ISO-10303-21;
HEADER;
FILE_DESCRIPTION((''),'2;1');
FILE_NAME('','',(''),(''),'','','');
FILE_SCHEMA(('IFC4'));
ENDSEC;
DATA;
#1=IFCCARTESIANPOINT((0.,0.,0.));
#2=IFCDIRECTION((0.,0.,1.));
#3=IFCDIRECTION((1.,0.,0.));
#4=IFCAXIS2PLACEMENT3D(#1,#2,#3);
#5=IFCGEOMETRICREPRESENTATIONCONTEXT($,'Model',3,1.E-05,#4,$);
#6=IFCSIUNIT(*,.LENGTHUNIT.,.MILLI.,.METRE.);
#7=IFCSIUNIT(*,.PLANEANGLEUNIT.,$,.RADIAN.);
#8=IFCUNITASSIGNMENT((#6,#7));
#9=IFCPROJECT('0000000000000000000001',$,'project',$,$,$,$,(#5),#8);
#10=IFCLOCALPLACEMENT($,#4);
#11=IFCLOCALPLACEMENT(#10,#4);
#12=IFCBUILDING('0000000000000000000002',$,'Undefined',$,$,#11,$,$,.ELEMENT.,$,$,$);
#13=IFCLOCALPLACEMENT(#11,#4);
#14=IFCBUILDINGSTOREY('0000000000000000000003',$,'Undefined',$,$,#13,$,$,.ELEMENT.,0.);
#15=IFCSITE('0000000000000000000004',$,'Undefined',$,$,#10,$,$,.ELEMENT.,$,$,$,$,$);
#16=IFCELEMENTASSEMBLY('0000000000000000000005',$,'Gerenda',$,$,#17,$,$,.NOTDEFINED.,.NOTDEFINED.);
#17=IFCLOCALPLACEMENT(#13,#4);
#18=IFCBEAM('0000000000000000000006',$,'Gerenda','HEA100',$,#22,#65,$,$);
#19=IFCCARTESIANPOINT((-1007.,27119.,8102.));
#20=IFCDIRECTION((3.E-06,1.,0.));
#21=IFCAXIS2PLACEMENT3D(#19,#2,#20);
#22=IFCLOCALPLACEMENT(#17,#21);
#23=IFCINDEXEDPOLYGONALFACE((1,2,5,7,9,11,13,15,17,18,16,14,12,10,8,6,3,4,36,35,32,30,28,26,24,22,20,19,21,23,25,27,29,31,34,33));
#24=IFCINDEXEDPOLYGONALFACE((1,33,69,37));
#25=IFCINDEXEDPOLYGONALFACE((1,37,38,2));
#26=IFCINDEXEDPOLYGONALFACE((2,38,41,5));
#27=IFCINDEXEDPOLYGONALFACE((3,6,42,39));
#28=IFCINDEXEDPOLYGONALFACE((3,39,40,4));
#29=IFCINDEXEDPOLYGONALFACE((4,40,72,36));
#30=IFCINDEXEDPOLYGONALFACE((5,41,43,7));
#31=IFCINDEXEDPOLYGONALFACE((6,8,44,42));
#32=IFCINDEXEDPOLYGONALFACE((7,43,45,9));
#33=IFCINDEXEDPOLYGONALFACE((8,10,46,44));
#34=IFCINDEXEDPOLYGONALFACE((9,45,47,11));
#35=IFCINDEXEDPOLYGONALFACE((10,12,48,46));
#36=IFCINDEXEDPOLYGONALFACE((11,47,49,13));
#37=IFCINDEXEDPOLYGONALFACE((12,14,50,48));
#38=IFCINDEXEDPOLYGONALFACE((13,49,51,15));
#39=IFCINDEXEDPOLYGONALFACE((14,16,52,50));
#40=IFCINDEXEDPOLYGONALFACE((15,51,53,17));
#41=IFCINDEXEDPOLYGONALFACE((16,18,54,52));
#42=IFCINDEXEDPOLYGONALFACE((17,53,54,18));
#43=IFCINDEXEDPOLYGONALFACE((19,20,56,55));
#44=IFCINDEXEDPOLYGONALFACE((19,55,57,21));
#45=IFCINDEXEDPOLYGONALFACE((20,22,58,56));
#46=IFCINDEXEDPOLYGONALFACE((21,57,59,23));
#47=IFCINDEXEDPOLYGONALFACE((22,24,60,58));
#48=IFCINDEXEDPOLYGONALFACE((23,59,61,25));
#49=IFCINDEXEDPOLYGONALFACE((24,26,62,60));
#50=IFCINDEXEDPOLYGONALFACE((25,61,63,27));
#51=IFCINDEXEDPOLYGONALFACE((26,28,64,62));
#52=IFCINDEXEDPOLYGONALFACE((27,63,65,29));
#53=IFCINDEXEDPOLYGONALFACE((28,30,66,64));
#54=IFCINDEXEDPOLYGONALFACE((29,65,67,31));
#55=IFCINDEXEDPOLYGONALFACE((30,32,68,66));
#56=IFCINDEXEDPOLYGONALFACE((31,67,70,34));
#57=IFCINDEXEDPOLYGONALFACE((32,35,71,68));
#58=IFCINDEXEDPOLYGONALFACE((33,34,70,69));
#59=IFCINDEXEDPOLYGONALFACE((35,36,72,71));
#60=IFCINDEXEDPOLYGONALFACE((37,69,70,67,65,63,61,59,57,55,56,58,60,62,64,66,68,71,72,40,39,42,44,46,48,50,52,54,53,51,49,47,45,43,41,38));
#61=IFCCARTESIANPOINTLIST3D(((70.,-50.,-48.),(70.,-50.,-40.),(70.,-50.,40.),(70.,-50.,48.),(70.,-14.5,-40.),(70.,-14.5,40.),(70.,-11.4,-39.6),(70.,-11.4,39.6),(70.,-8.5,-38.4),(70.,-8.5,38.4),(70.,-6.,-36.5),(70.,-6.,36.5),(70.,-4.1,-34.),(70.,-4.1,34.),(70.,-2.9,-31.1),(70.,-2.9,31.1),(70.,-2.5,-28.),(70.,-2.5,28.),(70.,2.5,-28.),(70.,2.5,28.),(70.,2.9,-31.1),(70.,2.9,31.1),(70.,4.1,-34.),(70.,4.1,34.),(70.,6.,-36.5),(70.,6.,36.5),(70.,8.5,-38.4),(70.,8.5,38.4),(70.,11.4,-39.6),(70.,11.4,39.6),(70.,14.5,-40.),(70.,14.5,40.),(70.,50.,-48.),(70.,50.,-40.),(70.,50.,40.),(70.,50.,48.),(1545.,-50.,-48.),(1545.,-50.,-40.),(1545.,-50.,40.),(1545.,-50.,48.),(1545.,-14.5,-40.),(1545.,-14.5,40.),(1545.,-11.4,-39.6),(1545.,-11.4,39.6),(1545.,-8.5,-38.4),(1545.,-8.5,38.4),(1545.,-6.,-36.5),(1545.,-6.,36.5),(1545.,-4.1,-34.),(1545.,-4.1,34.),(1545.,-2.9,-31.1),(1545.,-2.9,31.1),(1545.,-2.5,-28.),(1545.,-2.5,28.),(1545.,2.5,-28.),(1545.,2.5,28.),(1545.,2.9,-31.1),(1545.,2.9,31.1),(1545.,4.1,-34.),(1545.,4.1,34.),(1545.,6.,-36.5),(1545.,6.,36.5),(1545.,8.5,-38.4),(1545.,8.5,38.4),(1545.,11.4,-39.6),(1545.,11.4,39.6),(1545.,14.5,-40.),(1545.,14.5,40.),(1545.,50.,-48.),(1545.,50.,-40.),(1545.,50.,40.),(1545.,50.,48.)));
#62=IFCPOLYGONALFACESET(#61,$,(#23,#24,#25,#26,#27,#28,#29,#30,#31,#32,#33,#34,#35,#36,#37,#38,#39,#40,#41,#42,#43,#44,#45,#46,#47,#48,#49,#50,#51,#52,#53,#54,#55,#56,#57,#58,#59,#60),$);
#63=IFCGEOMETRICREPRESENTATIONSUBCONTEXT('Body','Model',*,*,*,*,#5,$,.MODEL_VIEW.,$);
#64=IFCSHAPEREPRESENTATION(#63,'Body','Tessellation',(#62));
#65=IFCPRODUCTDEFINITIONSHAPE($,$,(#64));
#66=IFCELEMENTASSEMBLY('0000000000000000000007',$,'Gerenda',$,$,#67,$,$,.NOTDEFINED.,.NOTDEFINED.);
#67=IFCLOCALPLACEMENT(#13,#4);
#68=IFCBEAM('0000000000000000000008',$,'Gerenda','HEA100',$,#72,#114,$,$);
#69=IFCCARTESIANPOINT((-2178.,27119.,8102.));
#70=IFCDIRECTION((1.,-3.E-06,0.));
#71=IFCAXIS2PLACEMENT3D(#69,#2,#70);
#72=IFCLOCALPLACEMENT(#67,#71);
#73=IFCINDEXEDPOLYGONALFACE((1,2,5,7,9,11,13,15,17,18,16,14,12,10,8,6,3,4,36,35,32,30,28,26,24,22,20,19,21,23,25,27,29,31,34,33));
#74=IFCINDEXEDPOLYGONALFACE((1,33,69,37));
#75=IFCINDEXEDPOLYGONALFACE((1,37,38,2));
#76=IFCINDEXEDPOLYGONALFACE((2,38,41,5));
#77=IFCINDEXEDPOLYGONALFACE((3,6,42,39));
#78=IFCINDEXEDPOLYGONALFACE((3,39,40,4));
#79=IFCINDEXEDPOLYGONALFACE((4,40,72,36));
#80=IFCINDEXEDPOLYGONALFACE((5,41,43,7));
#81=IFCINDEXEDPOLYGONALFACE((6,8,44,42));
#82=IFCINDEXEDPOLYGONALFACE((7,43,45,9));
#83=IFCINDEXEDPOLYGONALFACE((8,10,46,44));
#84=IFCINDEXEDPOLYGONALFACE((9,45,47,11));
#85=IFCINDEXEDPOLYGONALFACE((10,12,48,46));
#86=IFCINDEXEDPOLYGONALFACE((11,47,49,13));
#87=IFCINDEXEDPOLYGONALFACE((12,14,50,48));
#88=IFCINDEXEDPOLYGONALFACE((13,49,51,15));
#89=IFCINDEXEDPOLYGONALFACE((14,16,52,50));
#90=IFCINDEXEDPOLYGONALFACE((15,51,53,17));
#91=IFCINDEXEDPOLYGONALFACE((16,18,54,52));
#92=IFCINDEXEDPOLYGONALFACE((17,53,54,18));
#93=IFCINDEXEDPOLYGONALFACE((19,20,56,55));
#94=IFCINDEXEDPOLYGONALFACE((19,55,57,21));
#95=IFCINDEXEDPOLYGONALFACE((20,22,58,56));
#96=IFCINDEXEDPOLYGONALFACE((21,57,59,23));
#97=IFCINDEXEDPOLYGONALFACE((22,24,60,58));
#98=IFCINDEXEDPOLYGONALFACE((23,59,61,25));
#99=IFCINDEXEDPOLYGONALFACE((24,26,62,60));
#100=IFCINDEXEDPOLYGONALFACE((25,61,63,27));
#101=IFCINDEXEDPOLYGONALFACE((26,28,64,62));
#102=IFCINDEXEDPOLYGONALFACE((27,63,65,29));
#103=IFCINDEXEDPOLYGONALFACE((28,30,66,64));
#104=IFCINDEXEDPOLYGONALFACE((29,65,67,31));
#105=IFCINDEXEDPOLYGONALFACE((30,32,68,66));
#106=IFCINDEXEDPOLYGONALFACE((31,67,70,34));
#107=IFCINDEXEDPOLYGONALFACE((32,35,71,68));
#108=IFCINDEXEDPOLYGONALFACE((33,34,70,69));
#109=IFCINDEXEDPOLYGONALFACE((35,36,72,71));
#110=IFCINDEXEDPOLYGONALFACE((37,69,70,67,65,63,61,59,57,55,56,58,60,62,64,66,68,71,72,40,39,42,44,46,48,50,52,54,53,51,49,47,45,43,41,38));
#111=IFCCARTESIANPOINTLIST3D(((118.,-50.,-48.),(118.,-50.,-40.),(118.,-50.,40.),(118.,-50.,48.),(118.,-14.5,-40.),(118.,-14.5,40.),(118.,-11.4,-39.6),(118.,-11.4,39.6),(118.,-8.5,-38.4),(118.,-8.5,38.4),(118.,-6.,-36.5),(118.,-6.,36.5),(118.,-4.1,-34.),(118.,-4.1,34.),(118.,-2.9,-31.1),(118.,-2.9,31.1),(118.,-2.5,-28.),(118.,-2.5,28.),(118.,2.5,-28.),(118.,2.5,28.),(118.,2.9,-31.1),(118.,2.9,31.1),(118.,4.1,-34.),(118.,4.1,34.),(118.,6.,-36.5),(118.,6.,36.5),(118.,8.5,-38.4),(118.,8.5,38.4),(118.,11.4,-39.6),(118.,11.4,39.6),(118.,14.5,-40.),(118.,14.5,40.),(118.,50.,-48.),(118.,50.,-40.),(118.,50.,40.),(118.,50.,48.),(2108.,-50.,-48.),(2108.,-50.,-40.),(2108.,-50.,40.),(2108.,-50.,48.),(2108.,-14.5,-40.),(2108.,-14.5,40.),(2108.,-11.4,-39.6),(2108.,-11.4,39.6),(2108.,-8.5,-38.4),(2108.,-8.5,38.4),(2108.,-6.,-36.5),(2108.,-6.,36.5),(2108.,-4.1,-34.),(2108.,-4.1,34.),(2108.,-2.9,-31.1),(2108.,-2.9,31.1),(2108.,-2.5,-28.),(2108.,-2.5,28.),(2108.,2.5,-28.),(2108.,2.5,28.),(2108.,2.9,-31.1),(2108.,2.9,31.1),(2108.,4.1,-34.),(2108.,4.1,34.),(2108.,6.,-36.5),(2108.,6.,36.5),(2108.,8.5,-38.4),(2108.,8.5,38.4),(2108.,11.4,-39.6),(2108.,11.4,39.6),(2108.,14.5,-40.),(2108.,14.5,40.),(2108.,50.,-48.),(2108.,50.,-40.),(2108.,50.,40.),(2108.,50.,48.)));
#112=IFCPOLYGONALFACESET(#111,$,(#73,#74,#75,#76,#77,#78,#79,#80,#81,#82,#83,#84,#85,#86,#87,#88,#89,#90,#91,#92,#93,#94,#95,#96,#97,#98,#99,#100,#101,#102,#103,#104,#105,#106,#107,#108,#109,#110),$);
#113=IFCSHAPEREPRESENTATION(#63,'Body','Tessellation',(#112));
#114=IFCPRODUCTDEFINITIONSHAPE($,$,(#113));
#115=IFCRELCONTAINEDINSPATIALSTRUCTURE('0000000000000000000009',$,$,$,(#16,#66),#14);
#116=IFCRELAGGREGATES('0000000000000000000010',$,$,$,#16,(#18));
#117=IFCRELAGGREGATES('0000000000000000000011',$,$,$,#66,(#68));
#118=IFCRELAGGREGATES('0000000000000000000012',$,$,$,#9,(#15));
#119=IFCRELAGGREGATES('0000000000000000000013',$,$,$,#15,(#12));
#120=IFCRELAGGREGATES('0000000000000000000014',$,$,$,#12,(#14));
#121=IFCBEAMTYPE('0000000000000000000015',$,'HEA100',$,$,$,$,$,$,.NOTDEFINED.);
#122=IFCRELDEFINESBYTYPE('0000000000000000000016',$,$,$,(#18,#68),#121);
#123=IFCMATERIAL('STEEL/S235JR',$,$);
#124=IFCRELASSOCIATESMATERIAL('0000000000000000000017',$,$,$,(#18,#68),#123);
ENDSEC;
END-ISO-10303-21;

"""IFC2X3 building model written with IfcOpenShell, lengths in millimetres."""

from ifc_helpers import new_model, si_unit, frame, origin_with_axes, origin_2d_with_axis, place, context, subcontext, project, spatial, i_section, extrude, clip, halfspace, material, type_object, element, aggregate, save


model = new_model("IFC2X3")

# Units and contexts
model_context = context("Model", 3, precision=1e-05, world=origin_with_axes())
body_context = subcontext(model_context, "Body", "Model", "MODEL_VIEW")
ifc_project = project(units=[si_unit("LENGTHUNIT", "METRE", prefix="MILLI"), si_unit("PLANEANGLEUNIT", "RADIAN")], contexts=[model_context])

# Site, building, storey
site_placement = place(None, origin_with_axes())
site = spatial("IfcSite", under=ifc_project, at=site_placement, Name="Undefined", CompositionType="ELEMENT")
building_placement = place(site_placement, origin_with_axes())
building = spatial("IfcBuilding", under=site, at=building_placement, Name="Undefined", CompositionType="ELEMENT")
storey_placement = place(building_placement, origin_with_axes())
storey = spatial("IfcBuildingStorey", under=building, at=storey_placement, Name="Undefined", CompositionType="ELEMENT", Elevation=0.0)

# Element assemblies, beams
ifc_material_1 = material(Name="STEEL/S235JR")
beam_type_1 = type_object("IfcBeamType", Name="HEA100", PredefinedType="NOTDEFINED")
assembly_1_placement = place(storey_placement, origin_with_axes())
assembly_1 = element("IfcElementAssembly", 1, at=assembly_1_placement, inside=storey, Name="Gerenda", AssemblyPlace="NOTDEFINED", PredefinedType="NOTDEFINED")
beam_1_placement = place(assembly_1_placement, frame((-1007.0, 27119.0, 8102.0), z_axis=(0.0, 0.0, 1.0), x_axis=(0.000003, 1.0, 0.0)))
beam_1 = element("IfcBeam", 2, at=beam_1_placement, type_object=beam_type_1, material=ifc_material_1, Name="Gerenda", Description="HEA100", context=body_context, shape_type="Clipping", body=[
    clip(clip(extrude(i_section(OverallWidth=100.0, OverallDepth=96.0, WebThickness=5.0, FlangeThickness=8.0, FilletRadius=12.0, at=origin_2d_with_axis()), frame((1615.0, 0.0, 0.0), z_axis=(-1.0, 0.0, 0.0), x_axis=(0.0, -1.0, 0.0)), (0.0, 0.0, 1.0), 1615.0), halfspace(frame((1545.0, 0.0, -48.0), z_axis=(-1.0, 0.0, 0.0), x_axis=(0.0, 1.0, 0.0)), True)), halfspace(frame((70.0, 0.0, -48.0), z_axis=(1.0, 0.0, 0.0), x_axis=(0.0, -1.0, 0.0)), True)),
])
assembly_2_placement = place(storey_placement, origin_with_axes())
assembly_2 = element("IfcElementAssembly", 3, at=assembly_2_placement, inside=storey, Name="Gerenda", AssemblyPlace="NOTDEFINED", PredefinedType="NOTDEFINED")
beam_2_placement = place(assembly_2_placement, frame((-2178.0, 27119.0, 8102.0), z_axis=(0.0, 0.0, 1.0), x_axis=(1.0, -0.000003, 0.0)))
beam_2 = element("IfcBeam", 4, at=beam_2_placement, type_object=beam_type_1, material=ifc_material_1, Name="Gerenda", Description="HEA100", context=body_context, shape_type="Clipping", body=[
    clip(clip(extrude(i_section(OverallWidth=100.0, OverallDepth=96.0, WebThickness=5.0, FlangeThickness=8.0, FilletRadius=12.0, at=origin_2d_with_axis()), frame((2178.0, 0.0, 0.0), z_axis=(-1.0, 0.0, 0.0), x_axis=(0.0, -1.0, 0.0)), (0.0, 0.0, 1.0), 2178.0), halfspace(frame((2108.0, 0.0, -48.0), z_axis=(-1.0, 0.0, 0.0), x_axis=(0.0, 1.0, 0.0)), True)), halfspace(frame((118.0, 0.0, -48.0), z_axis=(1.0, -0.000002, 0.0), x_axis=(-0.000002, -1.0, 0.0)), True)),
])

aggregate(assembly_1, [beam_1])
aggregate(assembly_2, [beam_2])

save(model, "model.ifc")
